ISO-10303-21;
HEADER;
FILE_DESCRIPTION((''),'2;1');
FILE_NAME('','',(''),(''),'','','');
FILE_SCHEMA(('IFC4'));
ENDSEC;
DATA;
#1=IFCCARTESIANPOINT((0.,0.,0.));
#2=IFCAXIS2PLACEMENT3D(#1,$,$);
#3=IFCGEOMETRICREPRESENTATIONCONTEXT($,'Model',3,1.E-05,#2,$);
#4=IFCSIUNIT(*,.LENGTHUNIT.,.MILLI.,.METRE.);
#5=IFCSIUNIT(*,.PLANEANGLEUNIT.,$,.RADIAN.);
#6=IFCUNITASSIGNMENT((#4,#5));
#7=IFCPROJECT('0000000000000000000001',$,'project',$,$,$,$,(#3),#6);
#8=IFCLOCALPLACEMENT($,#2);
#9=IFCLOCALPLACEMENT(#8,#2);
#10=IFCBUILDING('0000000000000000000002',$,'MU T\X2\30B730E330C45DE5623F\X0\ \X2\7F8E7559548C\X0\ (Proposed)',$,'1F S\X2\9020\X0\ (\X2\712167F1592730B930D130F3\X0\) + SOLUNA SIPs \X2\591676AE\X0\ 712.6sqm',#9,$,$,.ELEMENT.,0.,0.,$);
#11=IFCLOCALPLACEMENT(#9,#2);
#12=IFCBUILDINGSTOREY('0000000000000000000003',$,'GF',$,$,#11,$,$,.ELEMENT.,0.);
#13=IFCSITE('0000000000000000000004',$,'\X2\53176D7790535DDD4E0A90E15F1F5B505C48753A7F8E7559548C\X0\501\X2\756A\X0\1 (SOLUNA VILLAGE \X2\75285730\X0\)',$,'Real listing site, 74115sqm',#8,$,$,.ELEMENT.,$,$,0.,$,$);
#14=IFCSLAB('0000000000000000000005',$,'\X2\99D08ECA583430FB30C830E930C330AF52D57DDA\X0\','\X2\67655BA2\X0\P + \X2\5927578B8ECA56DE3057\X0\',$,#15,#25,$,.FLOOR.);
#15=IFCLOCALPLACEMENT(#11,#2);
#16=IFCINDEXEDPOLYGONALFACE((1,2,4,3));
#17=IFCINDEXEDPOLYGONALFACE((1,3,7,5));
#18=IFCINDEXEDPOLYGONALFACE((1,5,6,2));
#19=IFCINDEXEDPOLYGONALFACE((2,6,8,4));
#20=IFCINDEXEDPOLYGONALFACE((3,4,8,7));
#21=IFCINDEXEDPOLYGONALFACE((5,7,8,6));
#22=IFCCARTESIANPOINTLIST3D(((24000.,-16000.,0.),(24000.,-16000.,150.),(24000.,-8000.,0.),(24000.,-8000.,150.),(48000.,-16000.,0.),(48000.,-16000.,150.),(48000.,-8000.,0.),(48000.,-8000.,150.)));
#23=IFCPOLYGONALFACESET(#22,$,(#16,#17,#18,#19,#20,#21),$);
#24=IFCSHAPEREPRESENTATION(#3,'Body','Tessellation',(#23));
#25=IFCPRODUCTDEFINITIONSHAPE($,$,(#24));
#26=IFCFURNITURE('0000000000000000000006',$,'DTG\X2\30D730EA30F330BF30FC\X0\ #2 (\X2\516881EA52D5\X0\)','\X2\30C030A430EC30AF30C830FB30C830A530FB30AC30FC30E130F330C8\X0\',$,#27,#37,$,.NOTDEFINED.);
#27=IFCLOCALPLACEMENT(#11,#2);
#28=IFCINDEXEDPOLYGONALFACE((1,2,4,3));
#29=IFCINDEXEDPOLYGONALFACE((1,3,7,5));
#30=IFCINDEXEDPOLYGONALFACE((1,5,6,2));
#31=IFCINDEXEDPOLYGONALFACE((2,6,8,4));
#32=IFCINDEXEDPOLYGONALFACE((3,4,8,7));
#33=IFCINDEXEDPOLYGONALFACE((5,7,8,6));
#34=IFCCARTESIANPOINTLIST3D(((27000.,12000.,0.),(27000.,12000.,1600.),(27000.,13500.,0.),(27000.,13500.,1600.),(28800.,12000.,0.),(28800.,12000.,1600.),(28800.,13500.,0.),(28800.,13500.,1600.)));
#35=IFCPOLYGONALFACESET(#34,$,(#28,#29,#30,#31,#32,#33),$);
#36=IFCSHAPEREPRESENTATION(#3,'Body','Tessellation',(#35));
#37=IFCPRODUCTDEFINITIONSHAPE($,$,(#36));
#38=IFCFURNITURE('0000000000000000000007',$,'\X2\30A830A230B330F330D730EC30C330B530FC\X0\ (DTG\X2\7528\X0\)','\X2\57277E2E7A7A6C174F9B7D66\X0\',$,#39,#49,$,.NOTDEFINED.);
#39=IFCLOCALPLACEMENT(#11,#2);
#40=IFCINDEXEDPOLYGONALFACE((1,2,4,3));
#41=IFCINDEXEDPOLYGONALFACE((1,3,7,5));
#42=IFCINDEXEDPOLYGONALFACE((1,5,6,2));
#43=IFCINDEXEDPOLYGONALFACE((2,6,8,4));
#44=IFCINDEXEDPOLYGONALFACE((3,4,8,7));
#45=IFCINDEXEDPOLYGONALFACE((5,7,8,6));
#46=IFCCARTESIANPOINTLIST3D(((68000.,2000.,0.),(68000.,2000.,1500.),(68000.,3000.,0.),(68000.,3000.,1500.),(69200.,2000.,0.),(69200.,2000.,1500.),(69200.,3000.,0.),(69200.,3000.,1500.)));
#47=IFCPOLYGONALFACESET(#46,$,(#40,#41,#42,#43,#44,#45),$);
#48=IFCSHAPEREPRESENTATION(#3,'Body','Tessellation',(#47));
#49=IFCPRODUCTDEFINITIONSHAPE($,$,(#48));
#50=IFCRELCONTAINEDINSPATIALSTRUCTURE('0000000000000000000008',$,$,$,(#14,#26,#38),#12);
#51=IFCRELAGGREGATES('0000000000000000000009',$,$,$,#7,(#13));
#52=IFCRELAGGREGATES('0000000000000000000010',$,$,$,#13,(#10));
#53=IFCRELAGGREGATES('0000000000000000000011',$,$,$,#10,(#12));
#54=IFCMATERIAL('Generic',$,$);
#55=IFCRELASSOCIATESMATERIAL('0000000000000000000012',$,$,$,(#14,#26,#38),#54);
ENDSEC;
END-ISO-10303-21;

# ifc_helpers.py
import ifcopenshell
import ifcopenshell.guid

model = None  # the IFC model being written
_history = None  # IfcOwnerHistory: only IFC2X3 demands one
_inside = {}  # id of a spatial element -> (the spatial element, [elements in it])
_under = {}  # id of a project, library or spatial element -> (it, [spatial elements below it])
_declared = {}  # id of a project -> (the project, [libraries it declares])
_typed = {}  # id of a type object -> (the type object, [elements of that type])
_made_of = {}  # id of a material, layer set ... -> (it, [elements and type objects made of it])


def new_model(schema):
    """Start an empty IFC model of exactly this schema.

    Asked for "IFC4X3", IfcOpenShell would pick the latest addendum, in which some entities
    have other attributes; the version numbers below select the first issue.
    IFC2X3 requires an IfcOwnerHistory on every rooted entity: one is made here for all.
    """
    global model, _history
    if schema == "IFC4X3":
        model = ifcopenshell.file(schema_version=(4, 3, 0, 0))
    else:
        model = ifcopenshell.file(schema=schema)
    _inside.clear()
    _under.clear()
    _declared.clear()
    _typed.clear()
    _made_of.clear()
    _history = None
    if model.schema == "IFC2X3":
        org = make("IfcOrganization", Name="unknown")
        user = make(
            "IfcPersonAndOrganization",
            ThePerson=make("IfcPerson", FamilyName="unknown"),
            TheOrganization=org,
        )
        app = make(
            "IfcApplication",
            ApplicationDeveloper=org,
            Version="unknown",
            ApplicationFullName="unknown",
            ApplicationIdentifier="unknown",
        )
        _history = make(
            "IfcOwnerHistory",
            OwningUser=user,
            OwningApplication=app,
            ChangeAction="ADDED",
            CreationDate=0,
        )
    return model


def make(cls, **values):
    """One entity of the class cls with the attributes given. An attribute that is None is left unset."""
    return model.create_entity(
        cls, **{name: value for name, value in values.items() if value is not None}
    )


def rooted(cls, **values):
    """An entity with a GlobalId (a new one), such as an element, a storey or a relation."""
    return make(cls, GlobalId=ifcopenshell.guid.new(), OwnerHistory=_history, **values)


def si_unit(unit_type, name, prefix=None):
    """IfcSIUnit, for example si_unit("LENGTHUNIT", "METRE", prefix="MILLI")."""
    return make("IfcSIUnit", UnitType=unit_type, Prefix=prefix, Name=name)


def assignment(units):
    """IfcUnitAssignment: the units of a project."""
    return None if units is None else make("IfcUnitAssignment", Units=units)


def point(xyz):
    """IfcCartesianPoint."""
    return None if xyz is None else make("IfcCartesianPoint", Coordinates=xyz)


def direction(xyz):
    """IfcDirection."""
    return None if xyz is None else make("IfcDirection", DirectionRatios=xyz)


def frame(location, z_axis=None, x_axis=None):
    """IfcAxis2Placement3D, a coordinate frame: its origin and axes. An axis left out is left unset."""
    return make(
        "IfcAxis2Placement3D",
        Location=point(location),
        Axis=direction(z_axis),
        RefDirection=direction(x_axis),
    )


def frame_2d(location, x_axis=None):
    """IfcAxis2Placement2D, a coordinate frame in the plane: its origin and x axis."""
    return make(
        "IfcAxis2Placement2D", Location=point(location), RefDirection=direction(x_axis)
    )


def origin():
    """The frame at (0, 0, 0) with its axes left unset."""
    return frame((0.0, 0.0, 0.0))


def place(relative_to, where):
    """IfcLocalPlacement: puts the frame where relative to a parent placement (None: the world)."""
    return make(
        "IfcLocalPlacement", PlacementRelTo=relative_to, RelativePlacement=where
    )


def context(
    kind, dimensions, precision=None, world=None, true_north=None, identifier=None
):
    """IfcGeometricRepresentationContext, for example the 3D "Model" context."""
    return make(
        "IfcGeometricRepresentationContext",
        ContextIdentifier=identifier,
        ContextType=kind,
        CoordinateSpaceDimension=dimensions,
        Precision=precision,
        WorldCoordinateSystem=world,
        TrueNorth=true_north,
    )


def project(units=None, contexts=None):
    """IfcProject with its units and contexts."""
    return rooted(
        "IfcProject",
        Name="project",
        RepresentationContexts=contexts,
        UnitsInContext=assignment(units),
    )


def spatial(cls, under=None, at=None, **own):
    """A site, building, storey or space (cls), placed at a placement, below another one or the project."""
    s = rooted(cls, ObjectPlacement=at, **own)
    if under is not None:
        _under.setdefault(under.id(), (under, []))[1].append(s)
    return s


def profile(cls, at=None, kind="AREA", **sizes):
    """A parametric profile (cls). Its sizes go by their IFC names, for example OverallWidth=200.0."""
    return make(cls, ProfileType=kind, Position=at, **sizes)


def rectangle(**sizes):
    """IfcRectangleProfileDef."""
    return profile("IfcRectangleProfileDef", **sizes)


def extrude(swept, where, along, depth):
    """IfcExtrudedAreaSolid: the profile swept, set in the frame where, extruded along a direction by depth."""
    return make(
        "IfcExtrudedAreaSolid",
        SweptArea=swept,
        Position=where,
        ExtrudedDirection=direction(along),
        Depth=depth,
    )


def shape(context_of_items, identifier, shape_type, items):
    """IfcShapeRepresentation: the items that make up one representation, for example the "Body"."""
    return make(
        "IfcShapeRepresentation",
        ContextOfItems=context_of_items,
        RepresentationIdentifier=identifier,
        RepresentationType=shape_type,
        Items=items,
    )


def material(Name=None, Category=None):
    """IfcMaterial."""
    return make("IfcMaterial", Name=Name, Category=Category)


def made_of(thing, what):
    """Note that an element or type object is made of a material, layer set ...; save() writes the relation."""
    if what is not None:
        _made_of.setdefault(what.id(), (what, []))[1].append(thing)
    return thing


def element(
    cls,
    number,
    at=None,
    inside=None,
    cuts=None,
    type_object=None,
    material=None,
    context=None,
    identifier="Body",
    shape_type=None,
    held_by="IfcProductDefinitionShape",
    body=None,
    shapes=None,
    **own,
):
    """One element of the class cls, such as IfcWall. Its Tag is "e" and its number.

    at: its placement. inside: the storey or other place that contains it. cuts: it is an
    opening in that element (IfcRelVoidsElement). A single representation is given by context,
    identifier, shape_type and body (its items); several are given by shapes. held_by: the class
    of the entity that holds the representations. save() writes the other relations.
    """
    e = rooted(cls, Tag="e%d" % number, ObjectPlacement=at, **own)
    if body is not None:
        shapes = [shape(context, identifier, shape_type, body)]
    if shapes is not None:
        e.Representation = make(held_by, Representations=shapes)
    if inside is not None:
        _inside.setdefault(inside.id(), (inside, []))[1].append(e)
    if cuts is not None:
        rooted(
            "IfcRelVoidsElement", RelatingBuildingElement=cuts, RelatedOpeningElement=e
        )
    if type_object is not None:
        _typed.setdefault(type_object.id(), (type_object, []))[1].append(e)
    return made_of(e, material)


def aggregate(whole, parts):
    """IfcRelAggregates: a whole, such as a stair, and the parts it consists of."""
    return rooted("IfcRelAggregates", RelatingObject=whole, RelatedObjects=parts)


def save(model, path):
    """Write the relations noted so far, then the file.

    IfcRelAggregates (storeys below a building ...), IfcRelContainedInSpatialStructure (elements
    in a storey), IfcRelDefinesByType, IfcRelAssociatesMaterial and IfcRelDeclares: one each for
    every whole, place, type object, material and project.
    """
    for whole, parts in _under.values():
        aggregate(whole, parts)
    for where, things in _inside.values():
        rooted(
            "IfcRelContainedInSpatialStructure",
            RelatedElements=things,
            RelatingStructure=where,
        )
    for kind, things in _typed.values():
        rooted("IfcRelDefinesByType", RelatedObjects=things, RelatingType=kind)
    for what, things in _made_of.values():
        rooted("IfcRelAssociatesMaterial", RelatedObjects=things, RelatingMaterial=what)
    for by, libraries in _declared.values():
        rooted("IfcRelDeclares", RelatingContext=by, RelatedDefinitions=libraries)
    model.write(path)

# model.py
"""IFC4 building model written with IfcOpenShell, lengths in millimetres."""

from ifc_helpers import new_model, si_unit, frame, frame_2d, origin, place, context, project, spatial, rectangle, extrude, material, element, save


model = new_model("IFC4")

# Units and contexts
model_context = context("Model", 3, precision=1e-05, world=origin())
ifc_project = project(units=[si_unit("LENGTHUNIT", "METRE", prefix="MILLI"), si_unit("PLANEANGLEUNIT", "RADIAN")], contexts=[model_context])

# Site, building, storey
site_placement = place(None, origin())
site = spatial("IfcSite", under=ifc_project, at=site_placement, Name="北海道川上郡弟子屈町美留和501番1 (SOLUNA VILLAGE 用地)", ObjectType="Real listing site, 74115sqm", CompositionType="ELEMENT", RefElevation=0.0)
building_placement = place(site_placement, origin())
building = spatial("IfcBuilding", under=site, at=building_placement, Name="MU Tシャツ工房 美留和 (Proposed)", ObjectType="1F S造 (無柱大スパン) + SOLUNA SIPs 外皮 712.6sqm", CompositionType="ELEMENT", ElevationOfRefHeight=0.0, ElevationOfTerrain=0.0)
storey_placement = place(building_placement, origin())
storey = spatial("IfcBuildingStorey", under=building, at=storey_placement, Name="GF", CompositionType="ELEMENT", Elevation=0.0)

# Slab
ifc_material_1 = material(Name="Generic")
slab_placement = place(storey_placement, frame((12000.0, -8000.0, 0.0)))
element("IfcSlab", 1, at=slab_placement, inside=storey, material=ifc_material_1, Name="駐車場・トラック動線", Description="来客P + 大型車回し", PredefinedType="FLOOR", context=model_context, shape_type="SweptSolid", body=[
    extrude(rectangle(XDim=24000.0, YDim=8000.0, at=frame_2d((12000.0, 4000.0))), frame((12000.0, -8000.0, 0.0)), (0.0, 0.0, 1.0), 150.0),
])

# Furniture
furniture_1_placement = place(storey_placement, frame((13500.0, 6000.0, 0.0)))
element("IfcFurniture", 2, at=furniture_1_placement, inside=storey, material=ifc_material_1, Name="DTGプリンター #2 (全自動)", Description="ダイレクト・トゥ・ガーメント", PredefinedType="NOTDEFINED", context=model_context, shape_type="SweptSolid", body=[
    extrude(rectangle(XDim=1800.0, YDim=1500.0, at=frame_2d((900.0, 750.0))), frame((13500.0, 6000.0, 0.0)), (0.0, 0.0, 1.0), 1600.0),
])
furniture_2_placement = place(storey_placement, frame((34000.0, 1000.0, 0.0)))
element("IfcFurniture", 3, at=furniture_2_placement, inside=storey, material=ifc_material_1, Name="エアコンプレッサー (DTG用)", Description="圧縮空気供給", PredefinedType="NOTDEFINED", context=model_context, shape_type="SweptSolid", body=[
    extrude(rectangle(XDim=1200.0, YDim=1000.0, at=frame_2d((600.0, 500.0))), frame((34000.0, 1000.0, 0.0)), (0.0, 0.0, 1.0), 1500.0),
])

save(model, "model.ifc")
